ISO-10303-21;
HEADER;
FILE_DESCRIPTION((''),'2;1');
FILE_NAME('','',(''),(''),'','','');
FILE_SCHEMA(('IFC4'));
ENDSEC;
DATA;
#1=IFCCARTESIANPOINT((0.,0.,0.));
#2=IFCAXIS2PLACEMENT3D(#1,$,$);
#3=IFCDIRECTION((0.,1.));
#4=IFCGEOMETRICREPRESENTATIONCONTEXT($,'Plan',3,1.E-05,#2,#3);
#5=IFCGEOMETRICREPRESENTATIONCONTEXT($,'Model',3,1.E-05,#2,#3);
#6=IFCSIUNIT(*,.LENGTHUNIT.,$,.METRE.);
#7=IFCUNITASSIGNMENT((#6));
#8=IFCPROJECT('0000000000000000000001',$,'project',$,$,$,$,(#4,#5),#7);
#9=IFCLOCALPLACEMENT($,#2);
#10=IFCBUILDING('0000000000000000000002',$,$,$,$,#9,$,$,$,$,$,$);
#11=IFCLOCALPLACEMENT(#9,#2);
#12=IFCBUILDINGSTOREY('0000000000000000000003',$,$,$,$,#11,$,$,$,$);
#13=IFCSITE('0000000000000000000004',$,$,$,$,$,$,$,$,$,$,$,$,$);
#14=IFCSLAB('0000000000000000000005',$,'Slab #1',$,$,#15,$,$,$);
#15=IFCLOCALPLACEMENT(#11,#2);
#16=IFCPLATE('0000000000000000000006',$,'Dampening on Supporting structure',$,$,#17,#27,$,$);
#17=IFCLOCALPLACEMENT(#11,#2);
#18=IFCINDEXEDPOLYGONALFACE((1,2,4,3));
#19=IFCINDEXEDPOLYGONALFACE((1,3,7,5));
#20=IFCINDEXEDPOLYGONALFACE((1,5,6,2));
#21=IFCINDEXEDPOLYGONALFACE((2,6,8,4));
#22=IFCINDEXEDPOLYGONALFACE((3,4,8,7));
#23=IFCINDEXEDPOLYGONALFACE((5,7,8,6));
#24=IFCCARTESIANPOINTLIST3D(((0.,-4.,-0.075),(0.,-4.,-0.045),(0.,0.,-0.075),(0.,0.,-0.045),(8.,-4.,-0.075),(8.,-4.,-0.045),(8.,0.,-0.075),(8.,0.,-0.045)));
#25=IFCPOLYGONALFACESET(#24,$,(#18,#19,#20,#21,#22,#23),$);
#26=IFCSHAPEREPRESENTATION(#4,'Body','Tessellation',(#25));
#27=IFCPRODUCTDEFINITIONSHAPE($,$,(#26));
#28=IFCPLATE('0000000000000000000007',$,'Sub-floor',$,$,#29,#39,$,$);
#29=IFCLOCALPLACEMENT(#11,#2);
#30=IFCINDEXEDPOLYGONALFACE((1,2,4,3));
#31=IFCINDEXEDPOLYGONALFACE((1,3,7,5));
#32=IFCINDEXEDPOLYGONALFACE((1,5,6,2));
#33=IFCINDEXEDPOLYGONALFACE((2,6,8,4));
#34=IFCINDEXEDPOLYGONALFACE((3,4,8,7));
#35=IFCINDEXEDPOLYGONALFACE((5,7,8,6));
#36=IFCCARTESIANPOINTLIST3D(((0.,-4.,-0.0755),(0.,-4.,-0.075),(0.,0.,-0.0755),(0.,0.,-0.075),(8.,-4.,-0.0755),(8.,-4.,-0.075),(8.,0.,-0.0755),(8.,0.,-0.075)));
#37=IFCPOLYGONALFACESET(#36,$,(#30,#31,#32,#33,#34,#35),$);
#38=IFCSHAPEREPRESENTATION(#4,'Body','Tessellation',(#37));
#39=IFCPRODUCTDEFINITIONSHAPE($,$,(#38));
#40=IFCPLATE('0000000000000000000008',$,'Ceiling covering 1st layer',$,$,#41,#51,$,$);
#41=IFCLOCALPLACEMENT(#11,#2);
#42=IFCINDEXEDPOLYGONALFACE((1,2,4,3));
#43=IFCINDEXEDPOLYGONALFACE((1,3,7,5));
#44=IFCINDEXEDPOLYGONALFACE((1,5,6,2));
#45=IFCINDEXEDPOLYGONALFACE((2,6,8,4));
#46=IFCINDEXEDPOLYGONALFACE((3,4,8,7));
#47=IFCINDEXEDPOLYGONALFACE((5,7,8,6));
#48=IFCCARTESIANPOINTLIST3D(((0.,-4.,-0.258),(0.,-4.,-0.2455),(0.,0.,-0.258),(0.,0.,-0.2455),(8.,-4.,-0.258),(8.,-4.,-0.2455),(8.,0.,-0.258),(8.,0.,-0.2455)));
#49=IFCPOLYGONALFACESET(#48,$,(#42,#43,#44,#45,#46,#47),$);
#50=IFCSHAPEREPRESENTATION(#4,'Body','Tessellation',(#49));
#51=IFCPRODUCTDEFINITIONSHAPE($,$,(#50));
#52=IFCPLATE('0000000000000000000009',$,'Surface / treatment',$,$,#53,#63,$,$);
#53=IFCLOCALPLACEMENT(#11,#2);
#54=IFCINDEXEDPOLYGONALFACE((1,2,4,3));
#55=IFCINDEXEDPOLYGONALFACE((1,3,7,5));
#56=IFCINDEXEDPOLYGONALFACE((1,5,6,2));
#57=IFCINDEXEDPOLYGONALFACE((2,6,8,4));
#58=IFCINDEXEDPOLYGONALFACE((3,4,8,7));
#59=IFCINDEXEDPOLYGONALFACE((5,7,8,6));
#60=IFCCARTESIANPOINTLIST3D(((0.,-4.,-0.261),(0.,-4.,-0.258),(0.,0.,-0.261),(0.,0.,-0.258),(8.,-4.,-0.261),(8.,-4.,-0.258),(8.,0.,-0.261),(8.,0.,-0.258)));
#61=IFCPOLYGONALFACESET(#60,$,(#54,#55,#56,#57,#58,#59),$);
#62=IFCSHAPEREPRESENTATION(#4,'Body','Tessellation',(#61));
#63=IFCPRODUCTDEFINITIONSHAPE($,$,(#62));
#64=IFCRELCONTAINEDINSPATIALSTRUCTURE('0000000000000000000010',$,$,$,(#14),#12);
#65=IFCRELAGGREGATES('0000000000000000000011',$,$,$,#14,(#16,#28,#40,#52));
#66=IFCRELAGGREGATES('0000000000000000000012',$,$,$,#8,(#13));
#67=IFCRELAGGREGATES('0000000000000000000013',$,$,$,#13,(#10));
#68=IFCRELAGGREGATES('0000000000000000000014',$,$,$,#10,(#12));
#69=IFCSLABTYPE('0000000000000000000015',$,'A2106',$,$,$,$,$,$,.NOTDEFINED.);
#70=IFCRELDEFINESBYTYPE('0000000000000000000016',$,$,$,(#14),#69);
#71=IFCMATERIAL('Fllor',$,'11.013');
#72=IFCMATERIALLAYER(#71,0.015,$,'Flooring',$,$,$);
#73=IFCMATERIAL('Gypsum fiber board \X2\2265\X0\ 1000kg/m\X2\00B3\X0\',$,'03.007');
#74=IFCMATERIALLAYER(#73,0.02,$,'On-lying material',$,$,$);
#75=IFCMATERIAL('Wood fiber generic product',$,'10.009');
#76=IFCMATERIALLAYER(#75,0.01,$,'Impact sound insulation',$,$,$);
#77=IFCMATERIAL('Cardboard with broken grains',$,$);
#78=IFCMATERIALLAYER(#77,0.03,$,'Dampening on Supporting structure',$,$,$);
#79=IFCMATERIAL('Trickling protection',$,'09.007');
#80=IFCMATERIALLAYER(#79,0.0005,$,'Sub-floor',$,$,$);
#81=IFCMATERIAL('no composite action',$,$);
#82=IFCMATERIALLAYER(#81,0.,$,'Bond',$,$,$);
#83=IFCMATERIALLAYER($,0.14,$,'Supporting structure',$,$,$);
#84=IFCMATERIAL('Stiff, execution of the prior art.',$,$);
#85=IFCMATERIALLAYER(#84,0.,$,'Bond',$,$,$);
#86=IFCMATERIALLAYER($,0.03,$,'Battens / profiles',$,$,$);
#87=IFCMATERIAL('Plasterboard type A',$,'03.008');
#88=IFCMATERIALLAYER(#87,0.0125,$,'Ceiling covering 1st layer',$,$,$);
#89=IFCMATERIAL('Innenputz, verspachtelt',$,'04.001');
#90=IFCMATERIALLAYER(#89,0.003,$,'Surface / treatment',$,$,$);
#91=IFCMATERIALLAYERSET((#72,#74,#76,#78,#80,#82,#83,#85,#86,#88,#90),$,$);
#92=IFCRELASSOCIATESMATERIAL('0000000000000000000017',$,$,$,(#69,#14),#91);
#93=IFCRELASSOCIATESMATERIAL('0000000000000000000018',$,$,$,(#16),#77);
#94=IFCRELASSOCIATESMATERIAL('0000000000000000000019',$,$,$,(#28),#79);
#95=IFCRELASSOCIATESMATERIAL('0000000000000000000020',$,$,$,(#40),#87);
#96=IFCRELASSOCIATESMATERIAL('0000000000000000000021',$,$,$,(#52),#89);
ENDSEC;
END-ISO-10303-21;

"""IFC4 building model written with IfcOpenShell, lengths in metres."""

from ifc_helpers import new_model, si_unit, direction, frame, frame_2d, origin, place, context, project, spatial, rectangle, extrude, material, layer, layer_set, type_object, element, aggregate, save


model = new_model("IFC4")

# Units and contexts
plan_context = context("Plan", 3, precision=1e-05, world=origin(), true_north=direction((0.0, 1.0)))
model_context = context("Model", 3, precision=1e-05, world=origin(), true_north=direction((0.0, 1.0)))
ifc_project = project(units=[si_unit("LENGTHUNIT", "METRE")], contexts=[plan_context, model_context])

# Site, building, storey
site = spatial("IfcSite", under=ifc_project)
building_placement = place(None, origin())
building = spatial("IfcBuilding", under=site, at=building_placement)
storey_placement = place(building_placement, origin())
storey = spatial("IfcBuildingStorey", under=building, at=storey_placement)

# Slab, plates
ifc_material_1 = material(Name="Fllor", Category="11.013")
ifc_layer_1 = layer(ifc_material_1, 0.015, Name="Flooring")
ifc_material_2 = material(Name="Gypsum fiber board ≥ 1000kg/m³", Category="03.007")
ifc_layer_2 = layer(ifc_material_2, 0.02, Name="On-lying material")
ifc_material_3 = material(Name="Wood fiber generic product", Category="10.009")
ifc_layer_3 = layer(ifc_material_3, 0.01, Name="Impact sound insulation")
ifc_material_4 = material(Name="Cardboard with broken grains")
ifc_layer_4 = layer(ifc_material_4, 0.03, Name="Dampening on Supporting structure")
ifc_material_5 = material(Name="Trickling protection", Category="09.007")
ifc_layer_5 = layer(ifc_material_5, 0.0005, Name="Sub-floor")
ifc_material_6 = material(Name="no composite action")
ifc_layer_6 = layer(ifc_material_6, 0.0, Name="Bond")
ifc_layer_7 = layer(None, 0.14, Name="Supporting structure")
ifc_material_7 = material(Name="Stiff, execution of the prior art.")
ifc_layer_8 = layer(ifc_material_7, 0.0, Name="Bond")
ifc_layer_9 = layer(None, 0.03, Name="Battens / profiles")
ifc_material_8 = material(Name="Plasterboard type A", Category="03.008")
ifc_layer_10 = layer(ifc_material_8, 0.0125, Name="Ceiling covering 1st layer")
ifc_material_9 = material(Name="Innenputz, verspachtelt", Category="04.001")
ifc_layer_11 = layer(ifc_material_9, 0.003, Name="Surface / treatment")
ifc_layer_set = layer_set([ifc_layer_1, ifc_layer_2, ifc_layer_3, ifc_layer_4, ifc_layer_5, ifc_layer_6, ifc_layer_7, ifc_layer_8, ifc_layer_9, ifc_layer_10, ifc_layer_11])
slab_type = type_object("IfcSlabType", Name="A2106", PredefinedType="NOTDEFINED", material=ifc_layer_set)
slab_placement = place(None, frame((0.0, 0.0, 0.0), z_axis=(0.0, 0.0, -1.0), x_axis=(1.0, 0.0, 0.0)))
slab = element("IfcSlab", 1, at=slab_placement, inside=storey, type_object=slab_type, material=ifc_layer_set, Name="Slab #1")
plate_1_placement = place(slab_placement, origin())
plate_1 = element("IfcPlate", 2, at=plate_1_placement, material=ifc_material_4, Name="Dampening on Supporting structure", context=plan_context, shape_type="SweptSolid", body=[
    extrude(rectangle(XDim=8.0, YDim=4.0, at=frame_2d((4.0, 2.0), x_axis=(1.0, 0.0))), frame((0.0, 0.0, 0.045), z_axis=(0.0, 0.0, 1.0), x_axis=(1.0, 0.0, 0.0)), (0.0, 0.0, 1.0), 0.03),
])
plate_2_placement = place(slab_placement, origin())
plate_2 = element("IfcPlate", 3, at=plate_2_placement, material=ifc_material_5, Name="Sub-floor", context=plan_context, shape_type="SweptSolid", body=[
    extrude(rectangle(XDim=8.0, YDim=4.0, at=frame_2d((4.0, 2.0), x_axis=(1.0, 0.0))), frame((0.0, 0.0, 0.075), z_axis=(0.0, 0.0, 1.0), x_axis=(1.0, 0.0, 0.0)), (0.0, 0.0, 1.0), 0.0005),
])
plate_3_placement = place(slab_placement, origin())
plate_3 = element("IfcPlate", 4, at=plate_3_placement, material=ifc_material_8, Name="Ceiling covering 1st layer", context=plan_context, shape_type="SweptSolid", body=[
    extrude(rectangle(XDim=8.0, YDim=4.0, at=frame_2d((4.0, 2.0), x_axis=(1.0, 0.0))), frame((0.0, 0.0, 0.2455), z_axis=(0.0, 0.0, 1.0), x_axis=(1.0, 0.0, 0.0)), (0.0, 0.0, 1.0), 0.0125),
])
plate_4_placement = place(slab_placement, origin())
plate_4 = element("IfcPlate", 5, at=plate_4_placement, material=ifc_material_9, Name="Surface / treatment", context=plan_context, shape_type="SweptSolid", body=[
    extrude(rectangle(XDim=8.0, YDim=4.0, at=frame_2d((4.0, 2.0), x_axis=(1.0, 0.0))), frame((0.0, 0.0, 0.258), z_axis=(0.0, 0.0, 1.0), x_axis=(1.0, 0.0, 0.0)), (0.0, 0.0, 1.0), 0.003),
])
aggregate(slab, [plate_1, plate_2, plate_3, plate_4])

save(model, "model.ifc")
